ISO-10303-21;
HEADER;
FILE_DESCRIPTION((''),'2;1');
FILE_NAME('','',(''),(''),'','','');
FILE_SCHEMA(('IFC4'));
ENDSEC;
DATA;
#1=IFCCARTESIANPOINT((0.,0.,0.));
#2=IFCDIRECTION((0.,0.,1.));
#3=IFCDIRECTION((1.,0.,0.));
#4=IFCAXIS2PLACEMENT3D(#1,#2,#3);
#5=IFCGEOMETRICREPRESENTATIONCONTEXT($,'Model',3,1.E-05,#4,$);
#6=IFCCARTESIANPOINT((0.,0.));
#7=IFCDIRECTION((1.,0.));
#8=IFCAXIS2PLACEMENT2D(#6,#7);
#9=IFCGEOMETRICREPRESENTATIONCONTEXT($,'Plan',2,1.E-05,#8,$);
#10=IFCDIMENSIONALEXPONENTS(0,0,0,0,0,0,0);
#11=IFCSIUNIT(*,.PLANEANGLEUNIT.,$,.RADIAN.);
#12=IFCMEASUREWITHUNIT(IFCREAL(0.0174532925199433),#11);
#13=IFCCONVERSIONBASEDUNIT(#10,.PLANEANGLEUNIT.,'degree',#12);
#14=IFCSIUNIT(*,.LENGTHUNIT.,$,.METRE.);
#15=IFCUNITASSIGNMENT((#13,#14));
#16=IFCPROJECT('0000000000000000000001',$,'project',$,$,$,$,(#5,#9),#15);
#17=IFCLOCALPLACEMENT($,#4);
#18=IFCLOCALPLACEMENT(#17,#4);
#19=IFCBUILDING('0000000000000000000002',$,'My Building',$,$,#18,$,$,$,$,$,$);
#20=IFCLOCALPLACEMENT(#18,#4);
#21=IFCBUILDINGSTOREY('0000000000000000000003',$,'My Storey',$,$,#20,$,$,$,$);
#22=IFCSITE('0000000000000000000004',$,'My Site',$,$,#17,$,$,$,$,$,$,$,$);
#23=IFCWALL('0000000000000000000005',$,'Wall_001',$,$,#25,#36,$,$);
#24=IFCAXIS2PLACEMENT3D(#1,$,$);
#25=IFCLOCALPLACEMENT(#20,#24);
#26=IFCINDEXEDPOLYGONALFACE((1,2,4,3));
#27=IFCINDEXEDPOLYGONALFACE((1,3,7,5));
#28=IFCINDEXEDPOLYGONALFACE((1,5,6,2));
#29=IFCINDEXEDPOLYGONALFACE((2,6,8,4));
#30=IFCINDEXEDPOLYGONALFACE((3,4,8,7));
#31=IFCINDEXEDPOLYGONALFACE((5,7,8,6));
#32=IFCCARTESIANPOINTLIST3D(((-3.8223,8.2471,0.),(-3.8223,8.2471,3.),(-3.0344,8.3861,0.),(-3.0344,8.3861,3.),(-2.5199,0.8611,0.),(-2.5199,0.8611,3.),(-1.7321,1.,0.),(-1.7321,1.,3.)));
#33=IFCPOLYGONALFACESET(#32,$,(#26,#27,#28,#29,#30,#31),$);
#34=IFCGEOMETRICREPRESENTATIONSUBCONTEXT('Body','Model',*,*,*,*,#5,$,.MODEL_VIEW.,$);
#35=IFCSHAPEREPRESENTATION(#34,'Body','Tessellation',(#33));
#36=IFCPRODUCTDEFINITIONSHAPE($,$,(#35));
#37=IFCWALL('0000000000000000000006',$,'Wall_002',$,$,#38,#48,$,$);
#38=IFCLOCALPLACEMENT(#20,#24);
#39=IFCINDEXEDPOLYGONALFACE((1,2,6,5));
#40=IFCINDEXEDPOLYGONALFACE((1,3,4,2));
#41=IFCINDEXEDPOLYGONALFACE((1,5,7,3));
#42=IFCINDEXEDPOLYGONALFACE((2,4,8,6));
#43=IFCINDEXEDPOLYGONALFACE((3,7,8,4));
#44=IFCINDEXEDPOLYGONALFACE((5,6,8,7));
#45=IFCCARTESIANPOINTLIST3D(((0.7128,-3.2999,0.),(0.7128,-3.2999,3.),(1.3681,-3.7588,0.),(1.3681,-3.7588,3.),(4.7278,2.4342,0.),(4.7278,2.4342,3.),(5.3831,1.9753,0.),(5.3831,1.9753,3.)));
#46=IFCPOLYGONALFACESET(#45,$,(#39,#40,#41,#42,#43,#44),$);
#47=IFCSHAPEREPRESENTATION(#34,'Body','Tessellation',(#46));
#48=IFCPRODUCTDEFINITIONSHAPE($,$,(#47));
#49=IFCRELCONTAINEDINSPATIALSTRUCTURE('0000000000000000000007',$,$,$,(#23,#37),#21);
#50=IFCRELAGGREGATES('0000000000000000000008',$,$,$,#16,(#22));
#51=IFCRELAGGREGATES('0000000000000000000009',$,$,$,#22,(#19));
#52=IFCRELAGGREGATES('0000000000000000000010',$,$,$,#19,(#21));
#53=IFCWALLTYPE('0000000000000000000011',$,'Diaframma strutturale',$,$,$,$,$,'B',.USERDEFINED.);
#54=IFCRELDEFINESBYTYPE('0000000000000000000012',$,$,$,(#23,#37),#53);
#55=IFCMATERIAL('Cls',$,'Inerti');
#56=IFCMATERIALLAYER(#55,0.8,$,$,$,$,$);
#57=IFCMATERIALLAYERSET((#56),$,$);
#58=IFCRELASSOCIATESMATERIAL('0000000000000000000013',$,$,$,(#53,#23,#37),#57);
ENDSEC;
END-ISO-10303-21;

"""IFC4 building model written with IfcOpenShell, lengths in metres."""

from ifc_helpers import new_model, entity, si_unit, converted_unit, frame, origin_with_axes, origin_2d_with_axis, place, context, subcontext, project, spatial, indexed_curve, outline, extrude, material, layer, layer_set, layer_usage, type_object, element, save


model = new_model("IFC4")

# Units and contexts
model_context = context("Model", 3, precision=1e-05, world=origin_with_axes())
plan_context = context("Plan", 2, precision=1e-05, world=origin_2d_with_axis())
body_context = subcontext(model_context, "Body", "Model", "MODEL_VIEW")
ifc_project = project(units=[converted_unit("PLANEANGLEUNIT", "degree", entity("IfcReal", 0.0174532925199433), si_unit("PLANEANGLEUNIT", "RADIAN"), dimensions=[0, 0, 0, 0, 0, 0, 0]), si_unit("LENGTHUNIT", "METRE")], contexts=[model_context, plan_context])

# Site, building, storey
site_placement = place(None, origin_with_axes())
site = spatial("IfcSite", under=ifc_project, at=site_placement, Name="My Site")
building_placement = place(site_placement, origin_with_axes())
building = spatial("IfcBuilding", under=site, at=building_placement, Name="My Building")
storey_placement = place(building_placement, origin_with_axes())
storey = spatial("IfcBuildingStorey", under=building, at=storey_placement, Name="My Storey")

# Walls
ifc_material = material(Name="Cls", Category="Inerti")
ifc_layer = layer(ifc_material, 0.8)
ifc_layer_set = layer_set([ifc_layer])
ifc_layer_usage_1 = layer_usage(ifc_layer_set, "AXIS2", "POSITIVE", 0.0)
wall_type = type_object("IfcWallType", Name="Diaframma strutturale", ElementType="B", PredefinedType="USERDEFINED", material=ifc_layer_set)
wall_1_placement = place(storey_placement, frame((-1.7321, 1.0, 0.0), z_axis=(0.0, 0.0, 1.0), x_axis=(-0.173648, 0.984808, 0.0)))
element("IfcWall", 1, at=wall_1_placement, inside=storey, type_object=wall_type, material=ifc_layer_usage_1, Name="Wall_001", context=body_context, shape_type="SweptSolid", body=[
    extrude(outline(indexed_curve([(0.0, 0.0), (0.0, 0.8), (7.5, 0.8), (7.5, 0.0), (0.0, 0.0)], self_intersect=False)), origin_with_axes(), (0.0, 0.0, 1.0), 3.0),
])
ifc_layer_usage_2 = layer_usage(ifc_layer_set, "AXIS2", "POSITIVE", 0.0)
wall_2_placement = place(storey_placement, frame((1.3681, -3.7588, 0.0), z_axis=(0.0, 0.0, 1.0), x_axis=(0.573576, 0.819152, 0.0)))
element("IfcWall", 2, at=wall_2_placement, inside=storey, type_object=wall_type, material=ifc_layer_usage_2, Name="Wall_002", context=body_context, shape_type="SweptSolid", body=[
    extrude(outline(indexed_curve([(0.0, 0.0), (0.0, 0.8), (7.0, 0.8), (7.0, 0.0), (0.0, 0.0)], self_intersect=False)), origin_with_axes(), (0.0, 0.0, 1.0), 3.0),
])

save(model, "model.ifc")
